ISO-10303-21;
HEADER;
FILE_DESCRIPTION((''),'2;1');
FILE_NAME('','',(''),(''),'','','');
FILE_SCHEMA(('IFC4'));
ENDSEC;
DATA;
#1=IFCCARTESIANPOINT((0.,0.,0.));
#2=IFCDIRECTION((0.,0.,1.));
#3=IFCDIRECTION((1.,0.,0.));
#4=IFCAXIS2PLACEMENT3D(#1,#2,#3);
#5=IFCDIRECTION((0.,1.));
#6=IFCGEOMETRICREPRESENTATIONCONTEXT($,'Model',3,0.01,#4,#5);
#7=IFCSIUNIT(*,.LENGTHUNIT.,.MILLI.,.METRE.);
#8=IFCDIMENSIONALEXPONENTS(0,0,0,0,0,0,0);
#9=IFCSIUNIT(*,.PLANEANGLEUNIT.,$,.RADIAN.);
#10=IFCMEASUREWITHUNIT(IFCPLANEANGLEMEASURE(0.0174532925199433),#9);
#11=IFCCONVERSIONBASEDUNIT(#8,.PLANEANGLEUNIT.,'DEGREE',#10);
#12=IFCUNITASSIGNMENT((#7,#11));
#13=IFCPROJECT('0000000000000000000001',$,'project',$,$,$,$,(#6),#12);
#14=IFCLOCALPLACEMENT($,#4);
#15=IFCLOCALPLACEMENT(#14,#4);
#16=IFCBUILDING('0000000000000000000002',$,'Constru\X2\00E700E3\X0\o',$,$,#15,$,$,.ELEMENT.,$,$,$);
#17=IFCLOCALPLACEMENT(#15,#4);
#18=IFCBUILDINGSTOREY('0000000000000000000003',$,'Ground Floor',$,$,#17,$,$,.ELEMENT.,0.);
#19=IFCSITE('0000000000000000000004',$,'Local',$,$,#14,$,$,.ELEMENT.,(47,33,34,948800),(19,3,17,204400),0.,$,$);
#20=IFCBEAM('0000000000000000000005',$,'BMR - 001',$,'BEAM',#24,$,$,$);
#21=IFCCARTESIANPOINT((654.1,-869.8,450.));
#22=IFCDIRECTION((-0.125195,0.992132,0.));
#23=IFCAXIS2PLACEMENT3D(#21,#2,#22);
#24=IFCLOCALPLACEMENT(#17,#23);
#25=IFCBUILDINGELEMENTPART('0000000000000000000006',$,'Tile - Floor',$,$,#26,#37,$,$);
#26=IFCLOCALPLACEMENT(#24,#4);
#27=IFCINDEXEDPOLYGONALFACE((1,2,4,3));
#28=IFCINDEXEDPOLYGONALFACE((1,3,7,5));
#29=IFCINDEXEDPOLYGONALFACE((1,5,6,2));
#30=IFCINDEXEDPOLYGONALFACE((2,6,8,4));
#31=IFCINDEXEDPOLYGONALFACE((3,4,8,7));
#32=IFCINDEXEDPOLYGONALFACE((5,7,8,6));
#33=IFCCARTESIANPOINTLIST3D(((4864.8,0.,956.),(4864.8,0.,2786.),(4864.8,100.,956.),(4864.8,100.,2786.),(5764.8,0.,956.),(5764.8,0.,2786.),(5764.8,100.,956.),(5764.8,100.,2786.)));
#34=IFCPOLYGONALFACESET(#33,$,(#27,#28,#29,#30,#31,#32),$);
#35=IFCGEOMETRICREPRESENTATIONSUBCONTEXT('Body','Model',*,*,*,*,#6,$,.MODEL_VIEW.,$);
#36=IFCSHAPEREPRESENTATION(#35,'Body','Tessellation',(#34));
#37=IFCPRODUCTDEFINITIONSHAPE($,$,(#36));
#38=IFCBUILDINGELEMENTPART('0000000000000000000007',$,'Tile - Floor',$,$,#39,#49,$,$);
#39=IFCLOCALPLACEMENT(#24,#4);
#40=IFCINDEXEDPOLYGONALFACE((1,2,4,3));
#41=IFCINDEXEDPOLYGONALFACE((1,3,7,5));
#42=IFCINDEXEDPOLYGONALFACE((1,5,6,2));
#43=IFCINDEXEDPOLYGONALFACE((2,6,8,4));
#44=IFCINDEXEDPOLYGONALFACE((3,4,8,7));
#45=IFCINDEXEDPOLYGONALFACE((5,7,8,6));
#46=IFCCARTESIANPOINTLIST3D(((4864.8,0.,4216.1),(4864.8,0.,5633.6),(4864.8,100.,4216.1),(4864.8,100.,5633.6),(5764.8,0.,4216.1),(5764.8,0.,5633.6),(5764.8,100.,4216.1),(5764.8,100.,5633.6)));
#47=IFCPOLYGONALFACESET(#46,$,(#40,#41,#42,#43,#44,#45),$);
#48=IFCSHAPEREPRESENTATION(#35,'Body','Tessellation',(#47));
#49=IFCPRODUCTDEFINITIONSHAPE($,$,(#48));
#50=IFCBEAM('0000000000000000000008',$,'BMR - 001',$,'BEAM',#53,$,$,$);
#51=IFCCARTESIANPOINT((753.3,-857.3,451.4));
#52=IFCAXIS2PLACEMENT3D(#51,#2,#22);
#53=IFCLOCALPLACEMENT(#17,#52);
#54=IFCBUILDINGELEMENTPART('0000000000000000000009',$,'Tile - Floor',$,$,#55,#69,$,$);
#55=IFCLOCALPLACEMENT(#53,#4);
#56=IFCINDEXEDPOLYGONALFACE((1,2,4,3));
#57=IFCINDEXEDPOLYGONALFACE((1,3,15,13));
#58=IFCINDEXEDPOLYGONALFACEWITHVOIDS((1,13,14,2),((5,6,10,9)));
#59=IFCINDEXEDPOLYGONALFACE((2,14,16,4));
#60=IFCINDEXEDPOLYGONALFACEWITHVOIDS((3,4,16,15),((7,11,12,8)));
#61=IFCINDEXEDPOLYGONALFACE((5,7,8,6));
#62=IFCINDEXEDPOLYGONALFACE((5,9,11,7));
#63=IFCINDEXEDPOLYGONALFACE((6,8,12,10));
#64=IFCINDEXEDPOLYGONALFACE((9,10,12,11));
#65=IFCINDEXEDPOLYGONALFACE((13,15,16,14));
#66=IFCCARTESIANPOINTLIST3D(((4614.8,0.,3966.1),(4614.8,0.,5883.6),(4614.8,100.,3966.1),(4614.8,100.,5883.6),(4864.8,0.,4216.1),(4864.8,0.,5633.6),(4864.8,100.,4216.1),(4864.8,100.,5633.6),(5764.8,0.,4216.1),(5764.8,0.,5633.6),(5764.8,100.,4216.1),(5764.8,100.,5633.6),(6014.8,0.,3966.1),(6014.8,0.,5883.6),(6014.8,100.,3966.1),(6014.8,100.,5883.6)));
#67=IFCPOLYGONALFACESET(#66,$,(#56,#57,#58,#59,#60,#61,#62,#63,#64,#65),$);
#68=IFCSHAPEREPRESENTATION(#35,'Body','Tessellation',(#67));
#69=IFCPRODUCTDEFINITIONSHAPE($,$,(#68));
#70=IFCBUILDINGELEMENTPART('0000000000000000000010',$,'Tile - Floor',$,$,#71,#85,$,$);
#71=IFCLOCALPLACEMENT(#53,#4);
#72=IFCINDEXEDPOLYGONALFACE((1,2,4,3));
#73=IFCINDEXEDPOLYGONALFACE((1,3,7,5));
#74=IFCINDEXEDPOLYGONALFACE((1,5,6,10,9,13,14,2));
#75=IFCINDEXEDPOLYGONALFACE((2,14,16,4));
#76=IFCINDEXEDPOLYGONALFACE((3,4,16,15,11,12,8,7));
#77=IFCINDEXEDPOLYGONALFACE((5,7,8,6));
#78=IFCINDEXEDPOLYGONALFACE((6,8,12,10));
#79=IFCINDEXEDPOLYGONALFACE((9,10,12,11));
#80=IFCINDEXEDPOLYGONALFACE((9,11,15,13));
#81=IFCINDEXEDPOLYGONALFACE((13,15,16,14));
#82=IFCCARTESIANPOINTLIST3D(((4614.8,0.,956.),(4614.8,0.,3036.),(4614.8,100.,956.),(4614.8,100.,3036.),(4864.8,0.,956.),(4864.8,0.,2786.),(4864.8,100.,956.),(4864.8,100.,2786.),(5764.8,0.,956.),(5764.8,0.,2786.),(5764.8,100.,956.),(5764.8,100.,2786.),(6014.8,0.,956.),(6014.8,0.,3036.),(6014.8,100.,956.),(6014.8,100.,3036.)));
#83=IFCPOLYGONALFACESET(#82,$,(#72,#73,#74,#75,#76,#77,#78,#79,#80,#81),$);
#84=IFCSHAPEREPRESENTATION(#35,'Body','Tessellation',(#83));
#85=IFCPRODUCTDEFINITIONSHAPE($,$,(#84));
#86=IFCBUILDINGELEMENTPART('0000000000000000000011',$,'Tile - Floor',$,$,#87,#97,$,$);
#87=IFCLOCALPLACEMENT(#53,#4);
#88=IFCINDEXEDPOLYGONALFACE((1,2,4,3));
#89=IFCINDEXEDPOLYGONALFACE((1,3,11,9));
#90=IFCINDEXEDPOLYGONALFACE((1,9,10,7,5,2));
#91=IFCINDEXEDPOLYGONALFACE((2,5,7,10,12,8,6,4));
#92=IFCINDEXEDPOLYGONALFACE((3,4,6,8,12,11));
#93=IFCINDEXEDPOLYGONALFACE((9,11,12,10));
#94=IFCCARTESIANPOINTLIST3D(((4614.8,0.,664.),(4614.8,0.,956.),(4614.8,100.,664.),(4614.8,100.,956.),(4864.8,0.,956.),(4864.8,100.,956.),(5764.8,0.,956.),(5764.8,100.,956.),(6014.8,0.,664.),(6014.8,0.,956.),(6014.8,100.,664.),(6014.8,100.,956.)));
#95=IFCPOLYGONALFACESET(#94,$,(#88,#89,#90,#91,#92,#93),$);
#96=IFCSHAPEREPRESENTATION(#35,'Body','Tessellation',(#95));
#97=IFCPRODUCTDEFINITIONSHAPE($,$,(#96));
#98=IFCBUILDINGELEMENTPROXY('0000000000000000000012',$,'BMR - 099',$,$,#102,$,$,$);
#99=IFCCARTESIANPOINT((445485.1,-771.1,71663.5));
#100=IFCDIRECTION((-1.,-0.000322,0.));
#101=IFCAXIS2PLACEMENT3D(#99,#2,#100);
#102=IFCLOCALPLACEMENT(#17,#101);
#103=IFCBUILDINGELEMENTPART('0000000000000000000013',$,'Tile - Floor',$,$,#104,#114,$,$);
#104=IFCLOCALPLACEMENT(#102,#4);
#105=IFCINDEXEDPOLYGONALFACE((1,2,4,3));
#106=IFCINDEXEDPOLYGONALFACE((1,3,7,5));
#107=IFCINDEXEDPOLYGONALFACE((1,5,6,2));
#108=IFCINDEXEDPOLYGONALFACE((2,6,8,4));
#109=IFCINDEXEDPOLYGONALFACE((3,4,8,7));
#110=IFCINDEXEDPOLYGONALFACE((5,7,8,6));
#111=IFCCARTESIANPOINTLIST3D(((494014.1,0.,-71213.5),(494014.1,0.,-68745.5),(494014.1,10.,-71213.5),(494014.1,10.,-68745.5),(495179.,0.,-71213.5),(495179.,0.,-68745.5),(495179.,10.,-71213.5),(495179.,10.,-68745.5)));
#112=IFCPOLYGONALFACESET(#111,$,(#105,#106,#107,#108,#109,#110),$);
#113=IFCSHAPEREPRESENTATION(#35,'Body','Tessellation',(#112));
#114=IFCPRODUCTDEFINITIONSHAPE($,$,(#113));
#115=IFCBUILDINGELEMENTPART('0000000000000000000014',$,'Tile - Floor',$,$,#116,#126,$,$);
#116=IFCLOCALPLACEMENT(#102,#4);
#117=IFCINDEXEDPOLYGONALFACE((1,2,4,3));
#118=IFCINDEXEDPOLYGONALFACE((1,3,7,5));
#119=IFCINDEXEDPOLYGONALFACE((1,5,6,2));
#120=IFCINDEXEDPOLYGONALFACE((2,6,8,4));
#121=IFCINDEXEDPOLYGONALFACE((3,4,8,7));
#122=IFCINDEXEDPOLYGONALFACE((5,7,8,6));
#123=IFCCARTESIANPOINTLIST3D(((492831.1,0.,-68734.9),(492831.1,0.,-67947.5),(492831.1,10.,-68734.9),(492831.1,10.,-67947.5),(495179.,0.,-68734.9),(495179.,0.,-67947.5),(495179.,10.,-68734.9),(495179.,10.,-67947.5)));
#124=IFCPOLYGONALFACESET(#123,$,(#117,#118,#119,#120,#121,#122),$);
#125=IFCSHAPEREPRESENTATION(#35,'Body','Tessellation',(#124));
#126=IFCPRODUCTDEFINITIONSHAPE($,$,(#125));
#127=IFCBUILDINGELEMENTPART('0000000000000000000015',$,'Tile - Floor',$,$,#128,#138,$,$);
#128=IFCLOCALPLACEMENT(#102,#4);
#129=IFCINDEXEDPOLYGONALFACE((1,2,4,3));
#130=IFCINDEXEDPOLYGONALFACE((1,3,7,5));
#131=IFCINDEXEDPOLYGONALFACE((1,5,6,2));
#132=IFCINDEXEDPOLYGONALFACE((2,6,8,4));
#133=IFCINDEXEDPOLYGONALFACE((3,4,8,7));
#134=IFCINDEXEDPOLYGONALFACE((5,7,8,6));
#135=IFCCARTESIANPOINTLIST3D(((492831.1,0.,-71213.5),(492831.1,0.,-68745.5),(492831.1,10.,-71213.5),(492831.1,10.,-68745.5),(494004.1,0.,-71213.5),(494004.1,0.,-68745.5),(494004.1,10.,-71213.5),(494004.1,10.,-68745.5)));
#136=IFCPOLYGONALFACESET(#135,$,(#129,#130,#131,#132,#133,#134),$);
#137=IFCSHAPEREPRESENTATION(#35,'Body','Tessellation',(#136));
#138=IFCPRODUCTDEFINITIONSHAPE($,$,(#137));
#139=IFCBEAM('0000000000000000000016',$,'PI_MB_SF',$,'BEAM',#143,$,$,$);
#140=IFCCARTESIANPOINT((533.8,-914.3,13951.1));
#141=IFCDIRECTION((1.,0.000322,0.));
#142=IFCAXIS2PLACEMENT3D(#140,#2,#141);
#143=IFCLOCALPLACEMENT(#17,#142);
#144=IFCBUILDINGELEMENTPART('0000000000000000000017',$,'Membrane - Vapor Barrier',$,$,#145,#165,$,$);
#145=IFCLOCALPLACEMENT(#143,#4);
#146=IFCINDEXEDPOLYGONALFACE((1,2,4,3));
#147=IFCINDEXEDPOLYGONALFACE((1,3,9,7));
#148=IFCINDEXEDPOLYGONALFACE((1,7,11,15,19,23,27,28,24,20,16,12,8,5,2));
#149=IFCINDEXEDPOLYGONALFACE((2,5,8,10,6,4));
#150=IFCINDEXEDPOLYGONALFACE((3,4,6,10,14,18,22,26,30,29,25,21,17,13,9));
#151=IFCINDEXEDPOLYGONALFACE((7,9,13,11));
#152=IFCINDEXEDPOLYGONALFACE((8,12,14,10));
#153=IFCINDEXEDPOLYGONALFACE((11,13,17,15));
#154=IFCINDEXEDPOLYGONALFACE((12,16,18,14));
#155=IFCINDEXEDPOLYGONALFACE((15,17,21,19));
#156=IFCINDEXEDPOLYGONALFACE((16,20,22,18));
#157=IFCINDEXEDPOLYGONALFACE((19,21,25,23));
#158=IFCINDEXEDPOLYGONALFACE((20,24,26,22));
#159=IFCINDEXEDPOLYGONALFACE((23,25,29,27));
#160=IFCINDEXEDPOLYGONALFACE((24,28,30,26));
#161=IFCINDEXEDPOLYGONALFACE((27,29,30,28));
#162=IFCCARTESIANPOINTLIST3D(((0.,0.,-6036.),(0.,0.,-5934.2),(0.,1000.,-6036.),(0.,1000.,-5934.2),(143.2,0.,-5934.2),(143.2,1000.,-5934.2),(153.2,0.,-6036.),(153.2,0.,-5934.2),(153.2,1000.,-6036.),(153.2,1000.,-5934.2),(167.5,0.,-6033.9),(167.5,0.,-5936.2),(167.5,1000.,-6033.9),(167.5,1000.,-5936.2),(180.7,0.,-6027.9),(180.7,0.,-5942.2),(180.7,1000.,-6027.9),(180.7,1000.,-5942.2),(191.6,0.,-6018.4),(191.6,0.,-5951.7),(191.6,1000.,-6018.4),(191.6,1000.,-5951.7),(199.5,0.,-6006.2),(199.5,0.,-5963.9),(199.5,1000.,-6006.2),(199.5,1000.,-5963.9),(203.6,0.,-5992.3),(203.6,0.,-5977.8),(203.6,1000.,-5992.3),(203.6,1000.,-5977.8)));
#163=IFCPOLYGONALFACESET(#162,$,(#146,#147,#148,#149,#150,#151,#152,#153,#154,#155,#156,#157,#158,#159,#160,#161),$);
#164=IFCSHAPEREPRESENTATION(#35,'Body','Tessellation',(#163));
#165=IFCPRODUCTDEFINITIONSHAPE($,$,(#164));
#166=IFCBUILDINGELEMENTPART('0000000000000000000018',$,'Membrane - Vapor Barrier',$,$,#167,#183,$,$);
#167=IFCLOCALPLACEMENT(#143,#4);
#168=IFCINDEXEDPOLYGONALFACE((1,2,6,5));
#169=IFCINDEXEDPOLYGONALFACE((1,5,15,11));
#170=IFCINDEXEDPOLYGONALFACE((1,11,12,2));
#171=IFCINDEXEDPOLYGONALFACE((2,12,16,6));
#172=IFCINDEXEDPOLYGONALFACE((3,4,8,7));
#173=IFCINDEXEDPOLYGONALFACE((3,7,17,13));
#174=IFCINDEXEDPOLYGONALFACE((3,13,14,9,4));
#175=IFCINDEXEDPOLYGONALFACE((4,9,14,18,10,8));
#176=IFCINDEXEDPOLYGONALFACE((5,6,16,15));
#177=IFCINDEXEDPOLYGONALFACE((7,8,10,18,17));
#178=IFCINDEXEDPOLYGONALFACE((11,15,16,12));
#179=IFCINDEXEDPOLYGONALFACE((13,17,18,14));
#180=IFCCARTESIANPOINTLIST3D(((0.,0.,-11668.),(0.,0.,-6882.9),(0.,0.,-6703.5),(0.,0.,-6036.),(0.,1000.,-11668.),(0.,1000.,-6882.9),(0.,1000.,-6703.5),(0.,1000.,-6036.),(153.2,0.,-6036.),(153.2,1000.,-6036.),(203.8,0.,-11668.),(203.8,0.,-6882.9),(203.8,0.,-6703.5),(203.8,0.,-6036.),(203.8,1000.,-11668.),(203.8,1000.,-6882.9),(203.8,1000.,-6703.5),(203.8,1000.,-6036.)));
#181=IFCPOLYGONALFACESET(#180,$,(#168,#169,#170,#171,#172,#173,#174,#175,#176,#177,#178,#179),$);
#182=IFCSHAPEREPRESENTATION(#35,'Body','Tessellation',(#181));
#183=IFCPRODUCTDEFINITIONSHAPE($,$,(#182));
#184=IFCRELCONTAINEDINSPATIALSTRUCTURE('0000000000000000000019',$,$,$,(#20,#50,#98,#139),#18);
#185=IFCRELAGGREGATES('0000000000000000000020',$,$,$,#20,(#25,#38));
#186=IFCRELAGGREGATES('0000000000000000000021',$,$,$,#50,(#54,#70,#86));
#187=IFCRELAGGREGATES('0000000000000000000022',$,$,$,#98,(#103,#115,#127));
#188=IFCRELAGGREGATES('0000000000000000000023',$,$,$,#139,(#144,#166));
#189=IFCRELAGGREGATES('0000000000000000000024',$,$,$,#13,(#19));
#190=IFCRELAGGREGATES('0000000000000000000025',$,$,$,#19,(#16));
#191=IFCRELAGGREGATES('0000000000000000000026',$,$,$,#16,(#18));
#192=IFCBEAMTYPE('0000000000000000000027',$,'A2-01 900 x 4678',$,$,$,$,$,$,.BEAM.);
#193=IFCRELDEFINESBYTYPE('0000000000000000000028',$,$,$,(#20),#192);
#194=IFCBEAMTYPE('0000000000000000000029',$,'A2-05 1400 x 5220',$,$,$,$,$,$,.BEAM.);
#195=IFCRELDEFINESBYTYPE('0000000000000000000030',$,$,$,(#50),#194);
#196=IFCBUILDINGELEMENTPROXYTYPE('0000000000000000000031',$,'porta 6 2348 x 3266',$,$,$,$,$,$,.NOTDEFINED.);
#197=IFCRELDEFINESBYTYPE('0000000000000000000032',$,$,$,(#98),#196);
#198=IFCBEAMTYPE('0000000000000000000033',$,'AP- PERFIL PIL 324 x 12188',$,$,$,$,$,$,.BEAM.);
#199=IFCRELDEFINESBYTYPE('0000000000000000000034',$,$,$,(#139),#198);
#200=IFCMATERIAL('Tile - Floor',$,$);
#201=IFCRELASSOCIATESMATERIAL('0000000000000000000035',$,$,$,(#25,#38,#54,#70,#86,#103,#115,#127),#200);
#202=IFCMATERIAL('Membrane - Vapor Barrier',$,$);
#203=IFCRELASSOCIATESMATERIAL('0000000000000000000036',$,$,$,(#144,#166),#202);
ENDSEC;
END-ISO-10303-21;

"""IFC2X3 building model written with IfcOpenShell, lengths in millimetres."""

from ifc_helpers import new_model, entity, si_unit, converted_unit, point, direction, frame, frame_2d, origin_with_axes, place, context, subcontext, project, spatial, polyline, circle_curve, parameter, trimmed, segment, composite_curve, outline, composite_profile, extrude, material, type_object, element, aggregate, save


model = new_model("IFC2X3")

# Units and contexts
model_context = context("Model", 3, precision=0.01, world=origin_with_axes(), true_north=direction((0.0, 1.0)))
body_context = subcontext(model_context, "Body", "Model", "MODEL_VIEW")
ifc_project = project(units=[si_unit("LENGTHUNIT", "METRE", prefix="MILLI"), converted_unit("PLANEANGLEUNIT", "DEGREE", entity("IfcPlaneAngleMeasure", 0.0174532925199433), si_unit("PLANEANGLEUNIT", "RADIAN"), dimensions=[0, 0, 0, 0, 0, 0, 0])], contexts=[model_context])

# Site, building, storey
site_placement = place(None, origin_with_axes())
site = spatial("IfcSite", under=ifc_project, at=site_placement, Name="Local", CompositionType="ELEMENT", RefLatitude=(47, 33, 34, 948800), RefLongitude=(19, 3, 17, 204400), RefElevation=0.0)
building_placement = place(site_placement, origin_with_axes())
building = spatial("IfcBuilding", under=site, at=building_placement, Name="Construção", CompositionType="ELEMENT")
storey_placement = place(building_placement, origin_with_axes())
storey = spatial("IfcBuildingStorey", under=building, at=storey_placement, Name="Ground Floor", CompositionType="ELEMENT", Elevation=0.0)

# Shared definitions
ifc_material_1 = material(Name="Membrane - Vapor Barrier")

# Beams, building element parts
beam_type_1 = type_object("IfcBeamType", Name="A2-01 900 x 4678", PredefinedType="BEAM")
beam_1_placement = place(storey_placement, frame((654.1, -869.8, 450.0), z_axis=(0.0, 0.0, 1.0), x_axis=(-0.125195, 0.992132, 0.0)))
beam_1 = element("IfcBeam", 1, at=beam_1_placement, inside=storey, type_object=beam_type_1, Name="BMR - 001", ObjectType="BEAM")
ifc_material_2 = material(Name="Tile - Floor")
building_element_part_1_placement = place(beam_1_placement, origin_with_axes())
building_element_part_1 = element("IfcBuildingElementPart", 2, at=building_element_part_1_placement, material=ifc_material_2, Name="Tile - Floor", context=body_context, shape_type="SweptSolid", body=[
    extrude(outline(polyline([(5764.8, 956.0), (5764.8, 2786.0), (4864.8, 2786.0), (4864.8, 956.0), (5764.8, 956.0)])), frame((0.0, 100.0, 0.0), z_axis=(0.0, -1.0, 0.0), x_axis=(1.0, 0.0, 0.0)), (0.0, 0.0, 1.0), 100.0),
])
building_element_part_2_placement = place(beam_1_placement, origin_with_axes())
building_element_part_2 = element("IfcBuildingElementPart", 3, at=building_element_part_2_placement, material=ifc_material_2, Name="Tile - Floor", context=body_context, shape_type="SweptSolid", body=[
    extrude(outline(polyline([(5764.8, 4216.1), (5764.8, 5633.6), (4864.8, 5633.6), (4864.8, 4216.1), (5764.8, 4216.1)])), frame((0.0, 100.0, 0.0), z_axis=(0.0, -1.0, 0.0), x_axis=(1.0, 0.0, 0.0)), (0.0, 0.0, 1.0), 100.0),
])
aggregate(beam_1, [building_element_part_1, building_element_part_2])
beam_type_2 = type_object("IfcBeamType", Name="A2-05 1400 x 5220", PredefinedType="BEAM")
beam_2_placement = place(storey_placement, frame((753.3, -857.3, 451.4), z_axis=(0.0, 0.0, 1.0), x_axis=(-0.125195, 0.992132, 0.0)))
beam_2 = element("IfcBeam", 4, at=beam_2_placement, inside=storey, type_object=beam_type_2, Name="BMR - 001", ObjectType="BEAM")
building_element_part_3_placement = place(beam_2_placement, origin_with_axes())
building_element_part_3 = element("IfcBuildingElementPart", 5, at=building_element_part_3_placement, material=ifc_material_2, Name="Tile - Floor", context=body_context, shape_type="SweptSolid", body=[
    extrude(outline(polyline([(4614.8, 3966.1), (6014.8, 3966.1), (6014.8, 5883.6), (4614.8, 5883.6), (4614.8, 3966.1)]), holes=[polyline([(4864.8, 4216.1), (4864.8, 5633.6), (5764.8, 5633.6), (5764.8, 4216.1), (4864.8, 4216.1)])]), frame((0.0, 100.0, 0.0), z_axis=(0.0, -1.0, 0.0), x_axis=(1.0, 0.0, 0.0)), (0.0, 0.0, 1.0), 100.0),
])
building_element_part_4_placement = place(beam_2_placement, origin_with_axes())
building_element_part_4 = element("IfcBuildingElementPart", 6, at=building_element_part_4_placement, material=ifc_material_2, Name="Tile - Floor", context=body_context, shape_type="SweptSolid", body=[
    extrude(outline(polyline([(6014.8, 3036.0), (4614.8, 3036.0), (4614.8, 956.0), (4864.8, 956.0), (4864.8, 2786.0), (5764.8, 2786.0), (5764.8, 956.0), (6014.8, 956.0), (6014.8, 3036.0)])), frame((0.0, 100.0, 0.0), z_axis=(0.0, -1.0, 0.0), x_axis=(1.0, 0.0, 0.0)), (0.0, 0.0, 1.0), 100.0),
])
building_element_part_5_placement = place(beam_2_placement, origin_with_axes())
building_element_part_5 = element("IfcBuildingElementPart", 7, at=building_element_part_5_placement, material=ifc_material_2, Name="Tile - Floor", context=body_context, shape_type="SweptSolid", body=[
    extrude(outline(polyline([(4614.8, 664.0), (6014.8, 664.0), (6014.8, 956.0), (5764.8, 956.0), (4864.8, 956.0), (4614.8, 956.0), (4614.8, 664.0)])), frame((0.0, 100.0, 0.0), z_axis=(0.0, -1.0, 0.0), x_axis=(1.0, 0.0, 0.0)), (0.0, 0.0, 1.0), 100.0),
])
aggregate(beam_2, [building_element_part_3, building_element_part_4, building_element_part_5])

# Building element proxy, building element parts
building_element_proxy_type = type_object("IfcBuildingElementProxyType", Name="porta 6 2348 x 3266", PredefinedType="NOTDEFINED")
proxy_placement = place(storey_placement, frame((445485.1, -771.1, 71663.5), z_axis=(0.0, 0.0, 1.0), x_axis=(-1.0, -0.000322, 0.0)))
proxy = element("IfcBuildingElementProxy", 8, at=proxy_placement, inside=storey, type_object=building_element_proxy_type, Name="BMR - 099")
building_element_part_6_placement = place(proxy_placement, origin_with_axes())
building_element_part_6 = element("IfcBuildingElementPart", 9, at=building_element_part_6_placement, material=ifc_material_2, Name="Tile - Floor", context=body_context, shape_type="SweptSolid", body=[
    extrude(outline(polyline([(494014.1, -68745.5), (494014.1, -71213.5), (495179.0, -71213.5), (495179.0, -68745.5), (494014.1, -68745.5)])), frame((0.0, 10.0, 0.0), z_axis=(0.0, -1.0, 0.0), x_axis=(1.0, 0.0, 0.0)), (0.0, 0.0, 1.0), 10.0),
])
building_element_part_7_placement = place(proxy_placement, origin_with_axes())
building_element_part_7 = element("IfcBuildingElementPart", 10, at=building_element_part_7_placement, material=ifc_material_2, Name="Tile - Floor", context=body_context, shape_type="SweptSolid", body=[
    extrude(outline(polyline([(492831.1, -67947.5), (492831.1, -68734.9), (495179.0, -68734.9), (495179.0, -67947.5), (492831.1, -67947.5)])), frame((0.0, 10.0, 0.0), z_axis=(0.0, -1.0, 0.0), x_axis=(1.0, 0.0, 0.0)), (0.0, 0.0, 1.0), 10.0),
])
building_element_part_8_placement = place(proxy_placement, origin_with_axes())
building_element_part_8 = element("IfcBuildingElementPart", 11, at=building_element_part_8_placement, material=ifc_material_2, Name="Tile - Floor", context=body_context, shape_type="SweptSolid", body=[
    extrude(outline(polyline([(492831.1, -68745.5), (492831.1, -71213.5), (494004.1, -71213.5), (494004.1, -68745.5), (492831.1, -68745.5)])), frame((0.0, 10.0, 0.0), z_axis=(0.0, -1.0, 0.0), x_axis=(1.0, 0.0, 0.0)), (0.0, 0.0, 1.0), 10.0),
])
aggregate(proxy, [building_element_part_6, building_element_part_7, building_element_part_8])

# Beam, building element parts
beam_type_3 = type_object("IfcBeamType", Name="AP- PERFIL PIL 324 x 12188", PredefinedType="BEAM")
beam_3_placement = place(storey_placement, frame((533.8, -914.3, 13951.1), z_axis=(0.0, 0.0, 1.0), x_axis=(1.0, 0.000322, 0.0)))
beam_3 = element("IfcBeam", 12, at=beam_3_placement, inside=storey, type_object=beam_type_3, Name="PI_MB_SF", ObjectType="BEAM")
building_element_part_9_placement = place(beam_3_placement, origin_with_axes())
building_element_part_9 = element("IfcBuildingElementPart", 13, at=building_element_part_9_placement, material=ifc_material_1, Name="Membrane - Vapor Barrier", context=body_context, shape_type="SweptSolid", body=[
    extrude(outline(composite_curve([segment(polyline([(0.0, -5934.2), (0.0, -6036.0), (153.2, -6036.0)]), True, "CONTINUOUS"), segment(trimmed(circle_curve(frame_2d((153.2, -5985.1), x_axis=(0.0, -1.0)), 50.9), [point((153.2, -6036.0)), parameter(0.0)], [point((153.2, -5934.2)), parameter(180.0)], True, "CARTESIAN"), True, "CONTINUOUS"), segment(polyline([(153.2, -5934.2), (143.2, -5934.2), (0.0, -5934.2)]), True, "CONTINUOUS")], self_intersect=False)), frame((0.0, 1000.0, 0.0), z_axis=(0.0, -1.0, 0.0), x_axis=(1.0, 0.0, 0.0)), (0.0, 0.0, 1.0), 1000.0),
])
building_element_part_10_placement = place(beam_3_placement, origin_with_axes())
building_element_part_10 = element("IfcBuildingElementPart", 14, at=building_element_part_10_placement, material=ifc_material_1, Name="Membrane - Vapor Barrier", context=body_context, shape_type="SweptSolid", body=[
    extrude(composite_profile([outline(polyline([(0.0, -11668.0), (203.8, -11668.0), (203.8, -6882.9), (0.0, -6882.9), (0.0, -11668.0)])), outline(polyline([(0.0, -6703.5), (203.8, -6703.5), (203.8, -6036.0), (153.2, -6036.0), (0.0, -6036.0), (0.0, -6703.5)]))]), frame((0.0, 1000.0, 0.0), z_axis=(0.0, -1.0, 0.0), x_axis=(1.0, 0.0, 0.0)), (0.0, 0.0, 1.0), 1000.0),
])
aggregate(beam_3, [building_element_part_9, building_element_part_10])

save(model, "model.ifc")
